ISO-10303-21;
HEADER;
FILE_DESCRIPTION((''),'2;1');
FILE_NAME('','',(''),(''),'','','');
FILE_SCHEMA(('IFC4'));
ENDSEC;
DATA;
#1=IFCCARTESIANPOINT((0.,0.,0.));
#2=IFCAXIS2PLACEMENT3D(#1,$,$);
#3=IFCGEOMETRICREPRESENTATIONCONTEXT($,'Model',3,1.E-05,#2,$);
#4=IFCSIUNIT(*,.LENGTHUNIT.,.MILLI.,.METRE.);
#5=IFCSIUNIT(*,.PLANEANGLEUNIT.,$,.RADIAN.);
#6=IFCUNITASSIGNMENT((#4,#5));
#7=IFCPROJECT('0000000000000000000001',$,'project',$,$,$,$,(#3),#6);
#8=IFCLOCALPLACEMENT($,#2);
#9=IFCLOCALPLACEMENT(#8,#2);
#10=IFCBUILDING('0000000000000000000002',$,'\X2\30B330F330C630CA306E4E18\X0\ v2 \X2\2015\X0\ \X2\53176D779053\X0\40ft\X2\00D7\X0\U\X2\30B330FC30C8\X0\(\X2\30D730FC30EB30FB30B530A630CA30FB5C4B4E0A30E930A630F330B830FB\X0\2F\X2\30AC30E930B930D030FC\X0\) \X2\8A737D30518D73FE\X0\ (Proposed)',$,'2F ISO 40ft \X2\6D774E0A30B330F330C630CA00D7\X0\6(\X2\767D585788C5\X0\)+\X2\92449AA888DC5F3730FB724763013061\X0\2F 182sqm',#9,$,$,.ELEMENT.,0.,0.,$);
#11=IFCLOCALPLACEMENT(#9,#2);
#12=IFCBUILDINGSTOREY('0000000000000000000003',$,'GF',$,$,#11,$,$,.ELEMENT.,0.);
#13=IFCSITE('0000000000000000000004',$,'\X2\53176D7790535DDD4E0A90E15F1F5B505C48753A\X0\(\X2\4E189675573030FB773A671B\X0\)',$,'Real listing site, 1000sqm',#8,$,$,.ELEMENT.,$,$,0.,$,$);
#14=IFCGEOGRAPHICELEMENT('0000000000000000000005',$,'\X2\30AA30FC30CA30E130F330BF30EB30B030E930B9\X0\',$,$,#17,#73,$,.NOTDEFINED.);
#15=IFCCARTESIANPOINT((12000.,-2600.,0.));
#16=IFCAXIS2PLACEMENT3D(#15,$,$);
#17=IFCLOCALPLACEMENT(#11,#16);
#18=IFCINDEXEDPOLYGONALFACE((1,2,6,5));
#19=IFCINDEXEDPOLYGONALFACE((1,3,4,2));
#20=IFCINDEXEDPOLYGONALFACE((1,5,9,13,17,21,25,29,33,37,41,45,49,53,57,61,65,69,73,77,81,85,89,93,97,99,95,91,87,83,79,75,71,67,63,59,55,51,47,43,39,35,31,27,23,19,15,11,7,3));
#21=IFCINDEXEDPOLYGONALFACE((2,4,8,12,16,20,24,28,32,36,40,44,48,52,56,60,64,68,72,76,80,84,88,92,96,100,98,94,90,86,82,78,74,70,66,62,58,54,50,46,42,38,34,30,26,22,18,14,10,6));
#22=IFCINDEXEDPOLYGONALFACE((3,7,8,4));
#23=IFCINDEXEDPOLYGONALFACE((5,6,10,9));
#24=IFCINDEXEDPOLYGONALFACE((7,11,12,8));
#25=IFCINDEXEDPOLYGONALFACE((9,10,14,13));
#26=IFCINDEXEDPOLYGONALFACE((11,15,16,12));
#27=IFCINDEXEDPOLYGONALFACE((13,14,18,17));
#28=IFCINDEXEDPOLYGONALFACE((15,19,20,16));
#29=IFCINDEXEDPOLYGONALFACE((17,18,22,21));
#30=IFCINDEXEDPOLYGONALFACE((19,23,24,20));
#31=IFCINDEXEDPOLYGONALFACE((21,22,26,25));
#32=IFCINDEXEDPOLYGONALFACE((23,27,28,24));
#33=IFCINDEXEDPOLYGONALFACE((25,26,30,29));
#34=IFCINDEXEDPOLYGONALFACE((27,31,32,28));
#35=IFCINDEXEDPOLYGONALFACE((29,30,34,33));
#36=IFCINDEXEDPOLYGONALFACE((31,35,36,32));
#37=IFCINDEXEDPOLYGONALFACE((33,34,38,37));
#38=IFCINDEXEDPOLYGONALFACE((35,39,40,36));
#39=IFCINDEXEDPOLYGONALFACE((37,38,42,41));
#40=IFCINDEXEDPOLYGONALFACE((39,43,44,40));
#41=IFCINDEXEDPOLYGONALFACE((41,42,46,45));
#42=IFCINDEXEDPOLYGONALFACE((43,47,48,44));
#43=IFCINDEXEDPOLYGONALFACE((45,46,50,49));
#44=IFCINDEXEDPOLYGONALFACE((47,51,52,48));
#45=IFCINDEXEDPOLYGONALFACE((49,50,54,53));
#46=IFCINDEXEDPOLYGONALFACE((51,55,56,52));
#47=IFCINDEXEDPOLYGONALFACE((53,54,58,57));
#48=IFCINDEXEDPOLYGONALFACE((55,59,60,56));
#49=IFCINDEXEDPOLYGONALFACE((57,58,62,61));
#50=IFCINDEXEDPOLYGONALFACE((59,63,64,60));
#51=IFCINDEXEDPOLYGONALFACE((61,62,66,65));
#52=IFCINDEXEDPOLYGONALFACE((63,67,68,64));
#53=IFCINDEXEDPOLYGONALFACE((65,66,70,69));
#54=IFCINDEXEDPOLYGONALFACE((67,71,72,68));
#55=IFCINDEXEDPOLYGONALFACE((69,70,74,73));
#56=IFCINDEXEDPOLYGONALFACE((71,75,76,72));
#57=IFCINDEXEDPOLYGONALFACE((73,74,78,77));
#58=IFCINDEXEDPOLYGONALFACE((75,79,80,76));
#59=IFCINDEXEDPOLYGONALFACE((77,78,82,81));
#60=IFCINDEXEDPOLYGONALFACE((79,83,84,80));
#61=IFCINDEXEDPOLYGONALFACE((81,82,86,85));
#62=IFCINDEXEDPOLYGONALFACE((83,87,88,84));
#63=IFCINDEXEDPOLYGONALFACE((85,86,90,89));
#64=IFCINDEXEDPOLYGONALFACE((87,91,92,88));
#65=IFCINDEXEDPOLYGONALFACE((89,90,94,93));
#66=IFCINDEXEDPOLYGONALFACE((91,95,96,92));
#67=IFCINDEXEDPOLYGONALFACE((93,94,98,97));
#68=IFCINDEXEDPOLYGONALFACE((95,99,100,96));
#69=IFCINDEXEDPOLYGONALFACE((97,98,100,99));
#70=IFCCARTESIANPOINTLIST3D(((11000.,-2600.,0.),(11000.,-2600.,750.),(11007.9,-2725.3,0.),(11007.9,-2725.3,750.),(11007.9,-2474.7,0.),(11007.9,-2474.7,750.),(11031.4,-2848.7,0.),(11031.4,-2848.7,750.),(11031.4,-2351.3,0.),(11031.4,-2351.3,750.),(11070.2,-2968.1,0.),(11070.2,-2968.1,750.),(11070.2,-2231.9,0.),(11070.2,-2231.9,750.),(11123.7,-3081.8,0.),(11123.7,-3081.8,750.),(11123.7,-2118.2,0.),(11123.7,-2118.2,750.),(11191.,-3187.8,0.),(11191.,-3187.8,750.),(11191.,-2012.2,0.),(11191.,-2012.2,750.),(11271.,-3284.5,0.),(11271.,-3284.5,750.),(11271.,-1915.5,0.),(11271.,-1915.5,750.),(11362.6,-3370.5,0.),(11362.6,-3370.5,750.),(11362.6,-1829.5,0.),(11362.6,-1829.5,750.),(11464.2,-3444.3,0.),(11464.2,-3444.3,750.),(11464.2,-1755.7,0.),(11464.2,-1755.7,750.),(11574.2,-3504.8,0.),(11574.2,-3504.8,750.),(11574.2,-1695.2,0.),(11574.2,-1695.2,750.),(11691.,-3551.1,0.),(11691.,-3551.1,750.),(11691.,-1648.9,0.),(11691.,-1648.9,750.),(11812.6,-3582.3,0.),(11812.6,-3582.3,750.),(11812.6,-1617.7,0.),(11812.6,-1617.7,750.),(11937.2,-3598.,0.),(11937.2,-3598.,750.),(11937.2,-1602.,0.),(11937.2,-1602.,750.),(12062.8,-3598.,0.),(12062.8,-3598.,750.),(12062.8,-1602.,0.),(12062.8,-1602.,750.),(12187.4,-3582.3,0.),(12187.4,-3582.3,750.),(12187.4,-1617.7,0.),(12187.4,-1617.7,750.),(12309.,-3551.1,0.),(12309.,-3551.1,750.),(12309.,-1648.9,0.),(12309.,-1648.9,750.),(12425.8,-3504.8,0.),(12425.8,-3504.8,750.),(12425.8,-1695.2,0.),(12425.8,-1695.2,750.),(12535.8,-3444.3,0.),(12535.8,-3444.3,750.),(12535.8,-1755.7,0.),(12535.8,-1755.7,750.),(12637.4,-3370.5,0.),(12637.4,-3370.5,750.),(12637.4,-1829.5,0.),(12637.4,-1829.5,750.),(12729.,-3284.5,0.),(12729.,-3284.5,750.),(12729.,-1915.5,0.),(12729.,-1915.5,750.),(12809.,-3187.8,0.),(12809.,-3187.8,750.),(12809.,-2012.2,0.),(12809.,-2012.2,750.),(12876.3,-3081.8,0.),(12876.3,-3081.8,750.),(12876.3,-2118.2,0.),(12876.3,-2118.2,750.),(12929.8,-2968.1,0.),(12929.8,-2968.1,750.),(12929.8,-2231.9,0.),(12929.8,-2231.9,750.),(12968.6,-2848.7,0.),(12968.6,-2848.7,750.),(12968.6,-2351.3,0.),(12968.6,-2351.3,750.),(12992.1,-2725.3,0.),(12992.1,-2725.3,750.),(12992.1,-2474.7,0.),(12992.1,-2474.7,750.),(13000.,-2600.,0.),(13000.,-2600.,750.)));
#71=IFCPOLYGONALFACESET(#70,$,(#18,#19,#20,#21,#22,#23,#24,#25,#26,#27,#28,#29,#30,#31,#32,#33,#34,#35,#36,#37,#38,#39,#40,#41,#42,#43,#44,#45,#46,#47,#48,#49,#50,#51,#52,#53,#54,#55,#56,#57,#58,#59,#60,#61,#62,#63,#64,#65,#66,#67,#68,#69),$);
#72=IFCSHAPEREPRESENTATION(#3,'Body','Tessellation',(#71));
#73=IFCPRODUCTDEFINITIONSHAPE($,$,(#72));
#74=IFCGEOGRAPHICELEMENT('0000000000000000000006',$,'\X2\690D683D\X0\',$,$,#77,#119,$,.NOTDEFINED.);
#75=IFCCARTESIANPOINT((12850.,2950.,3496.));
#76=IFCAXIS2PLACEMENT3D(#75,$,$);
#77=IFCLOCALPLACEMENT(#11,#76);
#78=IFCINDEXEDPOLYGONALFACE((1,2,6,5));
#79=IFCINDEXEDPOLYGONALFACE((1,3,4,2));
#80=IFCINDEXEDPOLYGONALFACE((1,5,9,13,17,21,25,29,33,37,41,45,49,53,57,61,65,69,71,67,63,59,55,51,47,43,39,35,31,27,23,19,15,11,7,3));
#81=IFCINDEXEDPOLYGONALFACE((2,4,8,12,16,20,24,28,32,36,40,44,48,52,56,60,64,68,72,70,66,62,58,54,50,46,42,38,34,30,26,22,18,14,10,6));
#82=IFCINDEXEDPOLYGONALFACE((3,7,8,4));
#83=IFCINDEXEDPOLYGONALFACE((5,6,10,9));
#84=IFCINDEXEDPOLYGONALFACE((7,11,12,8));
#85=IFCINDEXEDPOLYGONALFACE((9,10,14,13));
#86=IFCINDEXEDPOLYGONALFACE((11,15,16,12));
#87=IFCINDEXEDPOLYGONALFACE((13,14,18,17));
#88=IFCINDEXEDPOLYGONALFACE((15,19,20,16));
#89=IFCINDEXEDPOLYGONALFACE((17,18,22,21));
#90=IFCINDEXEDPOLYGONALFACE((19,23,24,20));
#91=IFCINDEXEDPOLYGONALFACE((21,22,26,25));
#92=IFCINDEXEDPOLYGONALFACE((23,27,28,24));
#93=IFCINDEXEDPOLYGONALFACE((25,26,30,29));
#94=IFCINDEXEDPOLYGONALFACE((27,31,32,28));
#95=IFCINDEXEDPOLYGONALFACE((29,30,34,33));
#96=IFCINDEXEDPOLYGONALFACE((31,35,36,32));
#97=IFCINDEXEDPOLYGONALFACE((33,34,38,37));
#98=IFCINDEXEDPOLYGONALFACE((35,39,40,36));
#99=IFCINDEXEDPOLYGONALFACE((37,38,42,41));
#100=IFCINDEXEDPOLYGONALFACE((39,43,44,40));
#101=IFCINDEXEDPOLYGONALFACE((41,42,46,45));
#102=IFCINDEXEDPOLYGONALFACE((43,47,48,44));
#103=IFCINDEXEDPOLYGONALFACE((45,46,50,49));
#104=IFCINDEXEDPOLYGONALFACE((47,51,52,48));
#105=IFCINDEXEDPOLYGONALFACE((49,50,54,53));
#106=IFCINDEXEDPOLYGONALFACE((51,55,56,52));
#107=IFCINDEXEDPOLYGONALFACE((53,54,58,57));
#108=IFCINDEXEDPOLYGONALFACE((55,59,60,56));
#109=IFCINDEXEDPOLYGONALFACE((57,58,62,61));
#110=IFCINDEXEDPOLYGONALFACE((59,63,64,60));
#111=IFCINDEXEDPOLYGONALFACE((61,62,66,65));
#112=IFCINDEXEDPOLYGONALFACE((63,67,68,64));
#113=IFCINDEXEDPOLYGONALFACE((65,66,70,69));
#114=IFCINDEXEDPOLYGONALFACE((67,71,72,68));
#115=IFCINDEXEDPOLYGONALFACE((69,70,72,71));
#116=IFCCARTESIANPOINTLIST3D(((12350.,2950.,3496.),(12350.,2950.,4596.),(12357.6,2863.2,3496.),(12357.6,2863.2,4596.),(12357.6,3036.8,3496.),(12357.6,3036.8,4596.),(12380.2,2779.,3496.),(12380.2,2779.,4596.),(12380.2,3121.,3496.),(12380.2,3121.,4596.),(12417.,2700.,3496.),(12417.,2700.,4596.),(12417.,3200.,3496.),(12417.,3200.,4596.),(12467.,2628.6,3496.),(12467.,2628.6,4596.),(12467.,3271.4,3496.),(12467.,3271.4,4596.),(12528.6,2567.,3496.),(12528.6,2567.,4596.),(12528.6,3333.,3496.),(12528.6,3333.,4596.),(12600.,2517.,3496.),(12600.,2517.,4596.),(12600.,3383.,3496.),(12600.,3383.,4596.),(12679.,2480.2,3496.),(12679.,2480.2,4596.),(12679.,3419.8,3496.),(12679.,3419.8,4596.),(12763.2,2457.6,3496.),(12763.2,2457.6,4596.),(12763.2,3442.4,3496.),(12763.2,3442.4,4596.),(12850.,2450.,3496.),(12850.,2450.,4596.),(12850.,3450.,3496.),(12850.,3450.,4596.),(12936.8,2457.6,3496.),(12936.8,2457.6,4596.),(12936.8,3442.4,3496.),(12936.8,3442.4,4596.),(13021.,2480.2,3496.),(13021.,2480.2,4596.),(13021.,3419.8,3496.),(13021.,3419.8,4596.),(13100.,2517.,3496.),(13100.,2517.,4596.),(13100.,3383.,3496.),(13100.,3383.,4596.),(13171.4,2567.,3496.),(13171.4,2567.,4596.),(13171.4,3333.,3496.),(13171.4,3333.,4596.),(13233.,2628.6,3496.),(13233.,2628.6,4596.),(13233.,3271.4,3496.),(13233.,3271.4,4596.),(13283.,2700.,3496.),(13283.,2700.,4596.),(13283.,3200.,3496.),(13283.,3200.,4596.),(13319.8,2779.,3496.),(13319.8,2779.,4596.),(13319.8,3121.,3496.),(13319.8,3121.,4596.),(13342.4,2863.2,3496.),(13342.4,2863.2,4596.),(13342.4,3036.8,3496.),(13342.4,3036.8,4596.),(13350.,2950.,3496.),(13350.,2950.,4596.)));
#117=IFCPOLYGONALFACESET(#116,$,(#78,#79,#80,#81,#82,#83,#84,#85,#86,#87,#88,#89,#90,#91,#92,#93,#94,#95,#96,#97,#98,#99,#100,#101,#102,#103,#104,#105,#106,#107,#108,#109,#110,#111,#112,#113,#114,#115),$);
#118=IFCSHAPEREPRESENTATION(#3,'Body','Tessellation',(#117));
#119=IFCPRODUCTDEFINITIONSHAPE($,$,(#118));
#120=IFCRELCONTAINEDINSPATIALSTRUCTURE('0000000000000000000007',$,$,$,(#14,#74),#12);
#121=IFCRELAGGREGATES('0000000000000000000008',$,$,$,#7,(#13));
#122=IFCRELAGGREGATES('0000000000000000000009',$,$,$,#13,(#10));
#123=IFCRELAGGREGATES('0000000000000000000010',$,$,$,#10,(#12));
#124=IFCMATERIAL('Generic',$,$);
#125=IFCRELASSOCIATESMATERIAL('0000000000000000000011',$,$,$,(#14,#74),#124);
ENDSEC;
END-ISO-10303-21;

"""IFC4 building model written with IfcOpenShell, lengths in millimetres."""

from ifc_helpers import new_model, si_unit, frame, origin, origin_2d, place, context, project, spatial, circle, extrude, material, element, save


model = new_model("IFC4")

# Units and contexts
model_context = context("Model", 3, precision=1e-05, world=origin())
ifc_project = project(units=[si_unit("LENGTHUNIT", "METRE", prefix="MILLI"), si_unit("PLANEANGLEUNIT", "RADIAN")], contexts=[model_context])

# Site, building, storey
site_placement = place(None, origin())
site = spatial("IfcSite", under=ifc_project, at=site_placement, Name="北海道川上郡弟子屈町(丘陵地・眺望)", ObjectType="Real listing site, 1000sqm", CompositionType="ELEMENT", RefElevation=0.0)
building_placement = place(site_placement, origin())
building = spatial("IfcBuilding", under=site, at=building_placement, Name="コンテナの丘 v2 ― 北海道40ft×Uコート(プール・サウナ・屋上ラウンジ・2Fガラスバー) 詳細再現 (Proposed)", ObjectType="2F ISO 40ft 海上コンテナ×6(白塗装)+鉄骨補強・片持ち2F 182sqm", CompositionType="ELEMENT", ElevationOfRefHeight=0.0, ElevationOfTerrain=0.0)
storey_placement = place(building_placement, origin())
storey = spatial("IfcBuildingStorey", under=building, at=storey_placement, Name="GF", CompositionType="ELEMENT", Elevation=0.0)

# Shared definitions
ifc_material = material(Name="Generic")

# Geographic elements
geographic_element_1_placement = place(storey_placement, frame((12000.0, -2600.0, 0.0)))
element("IfcGeographicElement", 1, at=geographic_element_1_placement, inside=storey, material=ifc_material, Name="オーナメンタルグラス", PredefinedType="NOTDEFINED", context=model_context, shape_type="SweptSolid", body=[
    extrude(circle(Radius=1000.0, at=origin_2d()), frame((12000.0, -2600.0, 0.0)), (0.0, 0.0, 1.0), 750.0),
])
geographic_element_2_placement = place(storey_placement, frame((12850.0, 2950.0, 3496.0)))
element("IfcGeographicElement", 2, at=geographic_element_2_placement, inside=storey, material=ifc_material, Name="植栽", PredefinedType="NOTDEFINED", context=model_context, shape_type="SweptSolid", body=[
    extrude(circle(Radius=500.0, at=origin_2d()), frame((12850.0, 2950.0, 3496.0)), (0.0, 0.0, 1.0), 1100.0),
])

save(model, "model.ifc")
